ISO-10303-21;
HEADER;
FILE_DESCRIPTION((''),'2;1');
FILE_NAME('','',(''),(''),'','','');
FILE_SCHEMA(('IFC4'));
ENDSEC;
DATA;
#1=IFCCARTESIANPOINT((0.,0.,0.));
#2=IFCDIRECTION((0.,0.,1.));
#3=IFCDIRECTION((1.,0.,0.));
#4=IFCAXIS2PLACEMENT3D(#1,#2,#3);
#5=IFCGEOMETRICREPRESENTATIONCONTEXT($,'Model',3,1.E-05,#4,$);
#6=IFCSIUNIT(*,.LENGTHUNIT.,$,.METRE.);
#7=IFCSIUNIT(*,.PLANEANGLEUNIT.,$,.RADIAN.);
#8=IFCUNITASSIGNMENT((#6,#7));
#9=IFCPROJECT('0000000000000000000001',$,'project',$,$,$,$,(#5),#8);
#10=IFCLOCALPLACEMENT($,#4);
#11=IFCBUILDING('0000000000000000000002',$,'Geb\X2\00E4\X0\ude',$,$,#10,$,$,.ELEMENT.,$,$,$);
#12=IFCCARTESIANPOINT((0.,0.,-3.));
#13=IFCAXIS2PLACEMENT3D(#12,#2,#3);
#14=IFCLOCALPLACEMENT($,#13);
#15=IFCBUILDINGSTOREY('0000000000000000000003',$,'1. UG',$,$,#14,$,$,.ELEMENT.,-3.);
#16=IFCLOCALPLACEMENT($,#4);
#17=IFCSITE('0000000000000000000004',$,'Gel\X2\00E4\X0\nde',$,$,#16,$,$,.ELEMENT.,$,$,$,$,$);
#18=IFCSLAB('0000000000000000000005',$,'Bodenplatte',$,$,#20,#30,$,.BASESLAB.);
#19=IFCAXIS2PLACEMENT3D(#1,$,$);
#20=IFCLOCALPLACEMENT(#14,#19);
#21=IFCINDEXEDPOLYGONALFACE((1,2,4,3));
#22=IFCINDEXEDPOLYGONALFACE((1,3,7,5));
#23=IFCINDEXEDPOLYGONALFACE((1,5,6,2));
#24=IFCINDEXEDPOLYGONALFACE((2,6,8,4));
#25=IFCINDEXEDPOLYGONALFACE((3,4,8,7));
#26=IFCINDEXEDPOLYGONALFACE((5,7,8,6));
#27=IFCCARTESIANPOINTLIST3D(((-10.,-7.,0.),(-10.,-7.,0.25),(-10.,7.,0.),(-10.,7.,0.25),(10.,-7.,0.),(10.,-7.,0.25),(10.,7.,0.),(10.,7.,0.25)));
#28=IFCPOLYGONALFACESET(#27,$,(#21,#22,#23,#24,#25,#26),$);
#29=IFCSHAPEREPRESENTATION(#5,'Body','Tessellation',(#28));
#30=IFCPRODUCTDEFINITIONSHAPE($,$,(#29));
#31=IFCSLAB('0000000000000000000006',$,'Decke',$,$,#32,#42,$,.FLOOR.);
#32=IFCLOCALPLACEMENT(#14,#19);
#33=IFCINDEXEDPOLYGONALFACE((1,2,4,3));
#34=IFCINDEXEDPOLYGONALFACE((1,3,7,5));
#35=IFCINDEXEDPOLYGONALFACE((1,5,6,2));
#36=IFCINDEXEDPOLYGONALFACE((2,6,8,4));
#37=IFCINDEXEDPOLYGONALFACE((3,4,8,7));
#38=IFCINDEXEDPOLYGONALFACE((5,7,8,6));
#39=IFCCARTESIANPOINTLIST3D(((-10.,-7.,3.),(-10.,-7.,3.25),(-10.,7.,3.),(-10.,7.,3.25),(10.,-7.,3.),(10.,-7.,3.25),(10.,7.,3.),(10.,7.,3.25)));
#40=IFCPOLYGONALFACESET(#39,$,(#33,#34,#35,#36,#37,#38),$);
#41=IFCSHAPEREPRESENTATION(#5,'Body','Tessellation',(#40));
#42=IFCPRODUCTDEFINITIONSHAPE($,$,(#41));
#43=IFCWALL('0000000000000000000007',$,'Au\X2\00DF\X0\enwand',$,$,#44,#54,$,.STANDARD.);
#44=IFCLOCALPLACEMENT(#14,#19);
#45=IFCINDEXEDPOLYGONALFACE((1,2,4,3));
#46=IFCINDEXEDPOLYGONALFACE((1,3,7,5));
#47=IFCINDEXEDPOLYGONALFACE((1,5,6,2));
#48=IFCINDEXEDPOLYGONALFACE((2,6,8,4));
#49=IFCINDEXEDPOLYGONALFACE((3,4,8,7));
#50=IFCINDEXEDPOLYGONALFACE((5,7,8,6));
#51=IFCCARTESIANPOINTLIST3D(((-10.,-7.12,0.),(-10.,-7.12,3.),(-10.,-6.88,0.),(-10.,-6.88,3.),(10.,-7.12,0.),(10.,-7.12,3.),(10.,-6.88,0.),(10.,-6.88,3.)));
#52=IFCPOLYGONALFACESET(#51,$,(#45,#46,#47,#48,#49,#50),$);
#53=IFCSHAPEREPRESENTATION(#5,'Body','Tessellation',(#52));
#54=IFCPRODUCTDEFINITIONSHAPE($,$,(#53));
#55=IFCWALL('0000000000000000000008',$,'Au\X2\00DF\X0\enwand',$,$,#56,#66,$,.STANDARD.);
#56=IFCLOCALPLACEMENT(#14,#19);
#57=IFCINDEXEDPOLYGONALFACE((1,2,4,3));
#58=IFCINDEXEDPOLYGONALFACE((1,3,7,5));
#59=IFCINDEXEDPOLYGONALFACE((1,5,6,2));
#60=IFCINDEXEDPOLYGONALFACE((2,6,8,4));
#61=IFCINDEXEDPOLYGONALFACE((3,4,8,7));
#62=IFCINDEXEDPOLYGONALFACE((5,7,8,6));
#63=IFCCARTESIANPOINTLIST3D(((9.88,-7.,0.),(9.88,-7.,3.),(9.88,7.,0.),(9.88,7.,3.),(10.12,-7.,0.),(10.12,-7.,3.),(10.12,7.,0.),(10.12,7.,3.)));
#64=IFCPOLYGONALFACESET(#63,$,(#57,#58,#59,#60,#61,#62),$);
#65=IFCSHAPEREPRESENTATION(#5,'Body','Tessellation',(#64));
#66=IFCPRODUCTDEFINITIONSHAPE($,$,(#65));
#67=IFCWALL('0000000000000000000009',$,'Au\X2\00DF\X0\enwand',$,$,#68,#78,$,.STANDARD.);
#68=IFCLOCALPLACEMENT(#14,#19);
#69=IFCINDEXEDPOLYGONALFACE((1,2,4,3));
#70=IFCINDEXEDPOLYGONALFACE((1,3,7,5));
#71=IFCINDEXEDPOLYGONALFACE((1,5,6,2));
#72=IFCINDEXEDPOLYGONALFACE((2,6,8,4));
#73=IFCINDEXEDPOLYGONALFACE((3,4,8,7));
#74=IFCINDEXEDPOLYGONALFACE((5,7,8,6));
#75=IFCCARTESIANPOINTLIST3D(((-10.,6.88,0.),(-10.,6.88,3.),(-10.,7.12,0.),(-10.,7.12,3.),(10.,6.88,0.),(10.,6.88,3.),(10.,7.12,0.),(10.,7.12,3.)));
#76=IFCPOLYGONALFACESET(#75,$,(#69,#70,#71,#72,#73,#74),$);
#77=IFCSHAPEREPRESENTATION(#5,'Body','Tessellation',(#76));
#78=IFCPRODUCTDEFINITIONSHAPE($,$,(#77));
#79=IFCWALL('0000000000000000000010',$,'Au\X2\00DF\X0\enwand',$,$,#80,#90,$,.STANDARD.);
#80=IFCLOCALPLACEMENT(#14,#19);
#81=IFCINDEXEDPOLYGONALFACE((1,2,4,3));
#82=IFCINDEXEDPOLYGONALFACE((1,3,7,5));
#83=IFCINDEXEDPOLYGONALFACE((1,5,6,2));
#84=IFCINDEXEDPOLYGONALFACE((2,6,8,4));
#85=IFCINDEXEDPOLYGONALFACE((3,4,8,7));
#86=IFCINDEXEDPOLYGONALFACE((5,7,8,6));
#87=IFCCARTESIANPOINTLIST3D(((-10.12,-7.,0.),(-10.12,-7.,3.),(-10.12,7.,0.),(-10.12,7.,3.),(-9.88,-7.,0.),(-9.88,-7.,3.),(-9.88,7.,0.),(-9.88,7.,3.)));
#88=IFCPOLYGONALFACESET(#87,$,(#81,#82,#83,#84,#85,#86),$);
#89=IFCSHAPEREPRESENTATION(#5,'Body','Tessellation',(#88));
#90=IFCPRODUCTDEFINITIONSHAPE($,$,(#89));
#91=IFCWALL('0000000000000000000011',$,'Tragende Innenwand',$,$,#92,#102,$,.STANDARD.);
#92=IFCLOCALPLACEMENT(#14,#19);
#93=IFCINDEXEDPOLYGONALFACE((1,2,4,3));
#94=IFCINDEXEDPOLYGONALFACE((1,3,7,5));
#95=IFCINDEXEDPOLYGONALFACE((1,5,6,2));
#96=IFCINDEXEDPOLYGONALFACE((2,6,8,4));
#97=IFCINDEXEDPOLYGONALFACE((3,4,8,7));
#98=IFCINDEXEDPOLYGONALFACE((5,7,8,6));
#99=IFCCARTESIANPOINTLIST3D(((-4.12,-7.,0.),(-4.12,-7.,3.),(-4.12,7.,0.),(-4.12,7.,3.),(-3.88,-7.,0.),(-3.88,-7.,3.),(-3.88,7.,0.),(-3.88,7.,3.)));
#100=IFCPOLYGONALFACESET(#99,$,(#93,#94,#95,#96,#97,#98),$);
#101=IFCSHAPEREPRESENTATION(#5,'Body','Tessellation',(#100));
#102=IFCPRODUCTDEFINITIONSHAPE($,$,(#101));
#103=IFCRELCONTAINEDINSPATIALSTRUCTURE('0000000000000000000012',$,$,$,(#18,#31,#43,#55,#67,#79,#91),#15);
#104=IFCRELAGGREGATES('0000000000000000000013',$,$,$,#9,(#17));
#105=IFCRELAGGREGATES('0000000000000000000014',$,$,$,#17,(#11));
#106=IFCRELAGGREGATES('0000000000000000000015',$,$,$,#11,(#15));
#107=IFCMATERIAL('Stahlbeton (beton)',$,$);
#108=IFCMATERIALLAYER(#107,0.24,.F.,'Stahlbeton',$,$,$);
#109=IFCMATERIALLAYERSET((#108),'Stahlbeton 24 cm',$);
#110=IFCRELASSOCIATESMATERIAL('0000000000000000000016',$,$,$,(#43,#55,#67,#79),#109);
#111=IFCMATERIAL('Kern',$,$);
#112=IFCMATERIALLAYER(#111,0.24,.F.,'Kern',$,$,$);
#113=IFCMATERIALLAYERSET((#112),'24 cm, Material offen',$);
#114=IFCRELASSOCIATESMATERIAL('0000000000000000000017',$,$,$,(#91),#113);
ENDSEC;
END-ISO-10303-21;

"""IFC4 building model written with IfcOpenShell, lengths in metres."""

from ifc_helpers import new_model, si_unit, frame, origin_with_axes, origin_2d, place, context, project, spatial, polyline, rectangle, outline, extrude, material, layer, layer_set, element, save


model = new_model("IFC4")

# Units and contexts
model_context = context("Model", 3, precision=1e-05, world=origin_with_axes())
ifc_project = project(units=[si_unit("LENGTHUNIT", "METRE"), si_unit("PLANEANGLEUNIT", "RADIAN")], contexts=[model_context])

# Site, building, storey
site_placement = place(None, origin_with_axes())
site = spatial("IfcSite", under=ifc_project, at=site_placement, Name="Gelände", CompositionType="ELEMENT")
building_placement = place(None, origin_with_axes())
building = spatial("IfcBuilding", under=site, at=building_placement, Name="Gebäude", CompositionType="ELEMENT")
storey_placement = place(None, frame((0.0, 0.0, -3.0), z_axis=(0.0, 0.0, 1.0), x_axis=(1.0, 0.0, 0.0)))
storey = spatial("IfcBuildingStorey", under=building, at=storey_placement, Name="1. UG", CompositionType="ELEMENT", Elevation=-3.0)

# Slabs
slab_1_placement = place(None, frame((0.0, 0.0, -3.0), z_axis=(0.0, 0.0, 1.0), x_axis=(1.0, 0.0, 0.0)))
element("IfcSlab", 1, at=slab_1_placement, inside=storey, Name="Bodenplatte", PredefinedType="BASESLAB", context=model_context, shape_type="SweptSolid", body=[
    extrude(outline(polyline([(-10.0, -7.0), (10.0, -7.0), (10.0, 7.0), (-10.0, 7.0), (-10.0, -7.0)])), origin_with_axes(), (0.0, 0.0, 1.0), 0.25),
])
slab_2_placement = place(None, origin_with_axes())
element("IfcSlab", 2, at=slab_2_placement, inside=storey, Name="Decke", PredefinedType="FLOOR", context=model_context, shape_type="SweptSolid", body=[
    extrude(outline(polyline([(-10.0, -7.0), (10.0, -7.0), (10.0, 7.0), (-10.0, 7.0), (-10.0, -7.0)])), origin_with_axes(), (0.0, 0.0, 1.0), 0.25),
])

# Walls
ifc_material_1 = material(Name="Stahlbeton (beton)")
ifc_layer_1 = layer(ifc_material_1, 0.24, ventilated=False, Name="Stahlbeton")
ifc_layer_set_1 = layer_set([ifc_layer_1], Name="Stahlbeton 24 cm")
wall_1_placement = place(None, frame((0.0, -7.0, -3.0), z_axis=(0.0, 0.0, 1.0), x_axis=(1.0, 0.0, 0.0)))
element("IfcWall", 3, at=wall_1_placement, inside=storey, material=ifc_layer_set_1, Name="Außenwand", PredefinedType="STANDARD", context=model_context, shape_type="SweptSolid", body=[
    extrude(rectangle(XDim=20.0, YDim=0.24, at=origin_2d()), origin_with_axes(), (0.0, 0.0, 1.0), 3.0),
])
wall_2_placement = place(None, frame((10.0, 0.0, -3.0), z_axis=(0.0, 0.0, 1.0), x_axis=(0.0, 1.0, 0.0)))
element("IfcWall", 4, at=wall_2_placement, inside=storey, material=ifc_layer_set_1, Name="Außenwand", PredefinedType="STANDARD", context=model_context, shape_type="SweptSolid", body=[
    extrude(rectangle(XDim=14.0, YDim=0.24, at=origin_2d()), origin_with_axes(), (0.0, 0.0, 1.0), 3.0),
])
wall_3_placement = place(None, frame((0.0, 7.0, -3.0), z_axis=(0.0, 0.0, 1.0), x_axis=(-1.0, 0.0, 0.0)))
element("IfcWall", 5, at=wall_3_placement, inside=storey, material=ifc_layer_set_1, Name="Außenwand", PredefinedType="STANDARD", context=model_context, shape_type="SweptSolid", body=[
    extrude(rectangle(XDim=20.0, YDim=0.24, at=origin_2d()), origin_with_axes(), (0.0, 0.0, 1.0), 3.0),
])
wall_4_placement = place(None, frame((-10.0, 0.0, -3.0), z_axis=(0.0, 0.0, 1.0), x_axis=(0.0, -1.0, 0.0)))
element("IfcWall", 6, at=wall_4_placement, inside=storey, material=ifc_layer_set_1, Name="Außenwand", PredefinedType="STANDARD", context=model_context, shape_type="SweptSolid", body=[
    extrude(rectangle(XDim=14.0, YDim=0.24, at=origin_2d()), origin_with_axes(), (0.0, 0.0, 1.0), 3.0),
])
ifc_material_2 = material(Name="Kern")
ifc_layer_2 = layer(ifc_material_2, 0.24, ventilated=False, Name="Kern")
ifc_layer_set_2 = layer_set([ifc_layer_2], Name="24 cm, Material offen")
wall_5_placement = place(None, frame((-4.0, 0.0, -3.0), z_axis=(0.0, 0.0, 1.0), x_axis=(0.0, 1.0, 0.0)))
element("IfcWall", 7, at=wall_5_placement, inside=storey, material=ifc_layer_set_2, Name="Tragende Innenwand", PredefinedType="STANDARD", context=model_context, shape_type="SweptSolid", body=[
    extrude(rectangle(XDim=14.0, YDim=0.24, at=origin_2d()), origin_with_axes(), (0.0, 0.0, 1.0), 3.0),
])

save(model, "model.ifc")
